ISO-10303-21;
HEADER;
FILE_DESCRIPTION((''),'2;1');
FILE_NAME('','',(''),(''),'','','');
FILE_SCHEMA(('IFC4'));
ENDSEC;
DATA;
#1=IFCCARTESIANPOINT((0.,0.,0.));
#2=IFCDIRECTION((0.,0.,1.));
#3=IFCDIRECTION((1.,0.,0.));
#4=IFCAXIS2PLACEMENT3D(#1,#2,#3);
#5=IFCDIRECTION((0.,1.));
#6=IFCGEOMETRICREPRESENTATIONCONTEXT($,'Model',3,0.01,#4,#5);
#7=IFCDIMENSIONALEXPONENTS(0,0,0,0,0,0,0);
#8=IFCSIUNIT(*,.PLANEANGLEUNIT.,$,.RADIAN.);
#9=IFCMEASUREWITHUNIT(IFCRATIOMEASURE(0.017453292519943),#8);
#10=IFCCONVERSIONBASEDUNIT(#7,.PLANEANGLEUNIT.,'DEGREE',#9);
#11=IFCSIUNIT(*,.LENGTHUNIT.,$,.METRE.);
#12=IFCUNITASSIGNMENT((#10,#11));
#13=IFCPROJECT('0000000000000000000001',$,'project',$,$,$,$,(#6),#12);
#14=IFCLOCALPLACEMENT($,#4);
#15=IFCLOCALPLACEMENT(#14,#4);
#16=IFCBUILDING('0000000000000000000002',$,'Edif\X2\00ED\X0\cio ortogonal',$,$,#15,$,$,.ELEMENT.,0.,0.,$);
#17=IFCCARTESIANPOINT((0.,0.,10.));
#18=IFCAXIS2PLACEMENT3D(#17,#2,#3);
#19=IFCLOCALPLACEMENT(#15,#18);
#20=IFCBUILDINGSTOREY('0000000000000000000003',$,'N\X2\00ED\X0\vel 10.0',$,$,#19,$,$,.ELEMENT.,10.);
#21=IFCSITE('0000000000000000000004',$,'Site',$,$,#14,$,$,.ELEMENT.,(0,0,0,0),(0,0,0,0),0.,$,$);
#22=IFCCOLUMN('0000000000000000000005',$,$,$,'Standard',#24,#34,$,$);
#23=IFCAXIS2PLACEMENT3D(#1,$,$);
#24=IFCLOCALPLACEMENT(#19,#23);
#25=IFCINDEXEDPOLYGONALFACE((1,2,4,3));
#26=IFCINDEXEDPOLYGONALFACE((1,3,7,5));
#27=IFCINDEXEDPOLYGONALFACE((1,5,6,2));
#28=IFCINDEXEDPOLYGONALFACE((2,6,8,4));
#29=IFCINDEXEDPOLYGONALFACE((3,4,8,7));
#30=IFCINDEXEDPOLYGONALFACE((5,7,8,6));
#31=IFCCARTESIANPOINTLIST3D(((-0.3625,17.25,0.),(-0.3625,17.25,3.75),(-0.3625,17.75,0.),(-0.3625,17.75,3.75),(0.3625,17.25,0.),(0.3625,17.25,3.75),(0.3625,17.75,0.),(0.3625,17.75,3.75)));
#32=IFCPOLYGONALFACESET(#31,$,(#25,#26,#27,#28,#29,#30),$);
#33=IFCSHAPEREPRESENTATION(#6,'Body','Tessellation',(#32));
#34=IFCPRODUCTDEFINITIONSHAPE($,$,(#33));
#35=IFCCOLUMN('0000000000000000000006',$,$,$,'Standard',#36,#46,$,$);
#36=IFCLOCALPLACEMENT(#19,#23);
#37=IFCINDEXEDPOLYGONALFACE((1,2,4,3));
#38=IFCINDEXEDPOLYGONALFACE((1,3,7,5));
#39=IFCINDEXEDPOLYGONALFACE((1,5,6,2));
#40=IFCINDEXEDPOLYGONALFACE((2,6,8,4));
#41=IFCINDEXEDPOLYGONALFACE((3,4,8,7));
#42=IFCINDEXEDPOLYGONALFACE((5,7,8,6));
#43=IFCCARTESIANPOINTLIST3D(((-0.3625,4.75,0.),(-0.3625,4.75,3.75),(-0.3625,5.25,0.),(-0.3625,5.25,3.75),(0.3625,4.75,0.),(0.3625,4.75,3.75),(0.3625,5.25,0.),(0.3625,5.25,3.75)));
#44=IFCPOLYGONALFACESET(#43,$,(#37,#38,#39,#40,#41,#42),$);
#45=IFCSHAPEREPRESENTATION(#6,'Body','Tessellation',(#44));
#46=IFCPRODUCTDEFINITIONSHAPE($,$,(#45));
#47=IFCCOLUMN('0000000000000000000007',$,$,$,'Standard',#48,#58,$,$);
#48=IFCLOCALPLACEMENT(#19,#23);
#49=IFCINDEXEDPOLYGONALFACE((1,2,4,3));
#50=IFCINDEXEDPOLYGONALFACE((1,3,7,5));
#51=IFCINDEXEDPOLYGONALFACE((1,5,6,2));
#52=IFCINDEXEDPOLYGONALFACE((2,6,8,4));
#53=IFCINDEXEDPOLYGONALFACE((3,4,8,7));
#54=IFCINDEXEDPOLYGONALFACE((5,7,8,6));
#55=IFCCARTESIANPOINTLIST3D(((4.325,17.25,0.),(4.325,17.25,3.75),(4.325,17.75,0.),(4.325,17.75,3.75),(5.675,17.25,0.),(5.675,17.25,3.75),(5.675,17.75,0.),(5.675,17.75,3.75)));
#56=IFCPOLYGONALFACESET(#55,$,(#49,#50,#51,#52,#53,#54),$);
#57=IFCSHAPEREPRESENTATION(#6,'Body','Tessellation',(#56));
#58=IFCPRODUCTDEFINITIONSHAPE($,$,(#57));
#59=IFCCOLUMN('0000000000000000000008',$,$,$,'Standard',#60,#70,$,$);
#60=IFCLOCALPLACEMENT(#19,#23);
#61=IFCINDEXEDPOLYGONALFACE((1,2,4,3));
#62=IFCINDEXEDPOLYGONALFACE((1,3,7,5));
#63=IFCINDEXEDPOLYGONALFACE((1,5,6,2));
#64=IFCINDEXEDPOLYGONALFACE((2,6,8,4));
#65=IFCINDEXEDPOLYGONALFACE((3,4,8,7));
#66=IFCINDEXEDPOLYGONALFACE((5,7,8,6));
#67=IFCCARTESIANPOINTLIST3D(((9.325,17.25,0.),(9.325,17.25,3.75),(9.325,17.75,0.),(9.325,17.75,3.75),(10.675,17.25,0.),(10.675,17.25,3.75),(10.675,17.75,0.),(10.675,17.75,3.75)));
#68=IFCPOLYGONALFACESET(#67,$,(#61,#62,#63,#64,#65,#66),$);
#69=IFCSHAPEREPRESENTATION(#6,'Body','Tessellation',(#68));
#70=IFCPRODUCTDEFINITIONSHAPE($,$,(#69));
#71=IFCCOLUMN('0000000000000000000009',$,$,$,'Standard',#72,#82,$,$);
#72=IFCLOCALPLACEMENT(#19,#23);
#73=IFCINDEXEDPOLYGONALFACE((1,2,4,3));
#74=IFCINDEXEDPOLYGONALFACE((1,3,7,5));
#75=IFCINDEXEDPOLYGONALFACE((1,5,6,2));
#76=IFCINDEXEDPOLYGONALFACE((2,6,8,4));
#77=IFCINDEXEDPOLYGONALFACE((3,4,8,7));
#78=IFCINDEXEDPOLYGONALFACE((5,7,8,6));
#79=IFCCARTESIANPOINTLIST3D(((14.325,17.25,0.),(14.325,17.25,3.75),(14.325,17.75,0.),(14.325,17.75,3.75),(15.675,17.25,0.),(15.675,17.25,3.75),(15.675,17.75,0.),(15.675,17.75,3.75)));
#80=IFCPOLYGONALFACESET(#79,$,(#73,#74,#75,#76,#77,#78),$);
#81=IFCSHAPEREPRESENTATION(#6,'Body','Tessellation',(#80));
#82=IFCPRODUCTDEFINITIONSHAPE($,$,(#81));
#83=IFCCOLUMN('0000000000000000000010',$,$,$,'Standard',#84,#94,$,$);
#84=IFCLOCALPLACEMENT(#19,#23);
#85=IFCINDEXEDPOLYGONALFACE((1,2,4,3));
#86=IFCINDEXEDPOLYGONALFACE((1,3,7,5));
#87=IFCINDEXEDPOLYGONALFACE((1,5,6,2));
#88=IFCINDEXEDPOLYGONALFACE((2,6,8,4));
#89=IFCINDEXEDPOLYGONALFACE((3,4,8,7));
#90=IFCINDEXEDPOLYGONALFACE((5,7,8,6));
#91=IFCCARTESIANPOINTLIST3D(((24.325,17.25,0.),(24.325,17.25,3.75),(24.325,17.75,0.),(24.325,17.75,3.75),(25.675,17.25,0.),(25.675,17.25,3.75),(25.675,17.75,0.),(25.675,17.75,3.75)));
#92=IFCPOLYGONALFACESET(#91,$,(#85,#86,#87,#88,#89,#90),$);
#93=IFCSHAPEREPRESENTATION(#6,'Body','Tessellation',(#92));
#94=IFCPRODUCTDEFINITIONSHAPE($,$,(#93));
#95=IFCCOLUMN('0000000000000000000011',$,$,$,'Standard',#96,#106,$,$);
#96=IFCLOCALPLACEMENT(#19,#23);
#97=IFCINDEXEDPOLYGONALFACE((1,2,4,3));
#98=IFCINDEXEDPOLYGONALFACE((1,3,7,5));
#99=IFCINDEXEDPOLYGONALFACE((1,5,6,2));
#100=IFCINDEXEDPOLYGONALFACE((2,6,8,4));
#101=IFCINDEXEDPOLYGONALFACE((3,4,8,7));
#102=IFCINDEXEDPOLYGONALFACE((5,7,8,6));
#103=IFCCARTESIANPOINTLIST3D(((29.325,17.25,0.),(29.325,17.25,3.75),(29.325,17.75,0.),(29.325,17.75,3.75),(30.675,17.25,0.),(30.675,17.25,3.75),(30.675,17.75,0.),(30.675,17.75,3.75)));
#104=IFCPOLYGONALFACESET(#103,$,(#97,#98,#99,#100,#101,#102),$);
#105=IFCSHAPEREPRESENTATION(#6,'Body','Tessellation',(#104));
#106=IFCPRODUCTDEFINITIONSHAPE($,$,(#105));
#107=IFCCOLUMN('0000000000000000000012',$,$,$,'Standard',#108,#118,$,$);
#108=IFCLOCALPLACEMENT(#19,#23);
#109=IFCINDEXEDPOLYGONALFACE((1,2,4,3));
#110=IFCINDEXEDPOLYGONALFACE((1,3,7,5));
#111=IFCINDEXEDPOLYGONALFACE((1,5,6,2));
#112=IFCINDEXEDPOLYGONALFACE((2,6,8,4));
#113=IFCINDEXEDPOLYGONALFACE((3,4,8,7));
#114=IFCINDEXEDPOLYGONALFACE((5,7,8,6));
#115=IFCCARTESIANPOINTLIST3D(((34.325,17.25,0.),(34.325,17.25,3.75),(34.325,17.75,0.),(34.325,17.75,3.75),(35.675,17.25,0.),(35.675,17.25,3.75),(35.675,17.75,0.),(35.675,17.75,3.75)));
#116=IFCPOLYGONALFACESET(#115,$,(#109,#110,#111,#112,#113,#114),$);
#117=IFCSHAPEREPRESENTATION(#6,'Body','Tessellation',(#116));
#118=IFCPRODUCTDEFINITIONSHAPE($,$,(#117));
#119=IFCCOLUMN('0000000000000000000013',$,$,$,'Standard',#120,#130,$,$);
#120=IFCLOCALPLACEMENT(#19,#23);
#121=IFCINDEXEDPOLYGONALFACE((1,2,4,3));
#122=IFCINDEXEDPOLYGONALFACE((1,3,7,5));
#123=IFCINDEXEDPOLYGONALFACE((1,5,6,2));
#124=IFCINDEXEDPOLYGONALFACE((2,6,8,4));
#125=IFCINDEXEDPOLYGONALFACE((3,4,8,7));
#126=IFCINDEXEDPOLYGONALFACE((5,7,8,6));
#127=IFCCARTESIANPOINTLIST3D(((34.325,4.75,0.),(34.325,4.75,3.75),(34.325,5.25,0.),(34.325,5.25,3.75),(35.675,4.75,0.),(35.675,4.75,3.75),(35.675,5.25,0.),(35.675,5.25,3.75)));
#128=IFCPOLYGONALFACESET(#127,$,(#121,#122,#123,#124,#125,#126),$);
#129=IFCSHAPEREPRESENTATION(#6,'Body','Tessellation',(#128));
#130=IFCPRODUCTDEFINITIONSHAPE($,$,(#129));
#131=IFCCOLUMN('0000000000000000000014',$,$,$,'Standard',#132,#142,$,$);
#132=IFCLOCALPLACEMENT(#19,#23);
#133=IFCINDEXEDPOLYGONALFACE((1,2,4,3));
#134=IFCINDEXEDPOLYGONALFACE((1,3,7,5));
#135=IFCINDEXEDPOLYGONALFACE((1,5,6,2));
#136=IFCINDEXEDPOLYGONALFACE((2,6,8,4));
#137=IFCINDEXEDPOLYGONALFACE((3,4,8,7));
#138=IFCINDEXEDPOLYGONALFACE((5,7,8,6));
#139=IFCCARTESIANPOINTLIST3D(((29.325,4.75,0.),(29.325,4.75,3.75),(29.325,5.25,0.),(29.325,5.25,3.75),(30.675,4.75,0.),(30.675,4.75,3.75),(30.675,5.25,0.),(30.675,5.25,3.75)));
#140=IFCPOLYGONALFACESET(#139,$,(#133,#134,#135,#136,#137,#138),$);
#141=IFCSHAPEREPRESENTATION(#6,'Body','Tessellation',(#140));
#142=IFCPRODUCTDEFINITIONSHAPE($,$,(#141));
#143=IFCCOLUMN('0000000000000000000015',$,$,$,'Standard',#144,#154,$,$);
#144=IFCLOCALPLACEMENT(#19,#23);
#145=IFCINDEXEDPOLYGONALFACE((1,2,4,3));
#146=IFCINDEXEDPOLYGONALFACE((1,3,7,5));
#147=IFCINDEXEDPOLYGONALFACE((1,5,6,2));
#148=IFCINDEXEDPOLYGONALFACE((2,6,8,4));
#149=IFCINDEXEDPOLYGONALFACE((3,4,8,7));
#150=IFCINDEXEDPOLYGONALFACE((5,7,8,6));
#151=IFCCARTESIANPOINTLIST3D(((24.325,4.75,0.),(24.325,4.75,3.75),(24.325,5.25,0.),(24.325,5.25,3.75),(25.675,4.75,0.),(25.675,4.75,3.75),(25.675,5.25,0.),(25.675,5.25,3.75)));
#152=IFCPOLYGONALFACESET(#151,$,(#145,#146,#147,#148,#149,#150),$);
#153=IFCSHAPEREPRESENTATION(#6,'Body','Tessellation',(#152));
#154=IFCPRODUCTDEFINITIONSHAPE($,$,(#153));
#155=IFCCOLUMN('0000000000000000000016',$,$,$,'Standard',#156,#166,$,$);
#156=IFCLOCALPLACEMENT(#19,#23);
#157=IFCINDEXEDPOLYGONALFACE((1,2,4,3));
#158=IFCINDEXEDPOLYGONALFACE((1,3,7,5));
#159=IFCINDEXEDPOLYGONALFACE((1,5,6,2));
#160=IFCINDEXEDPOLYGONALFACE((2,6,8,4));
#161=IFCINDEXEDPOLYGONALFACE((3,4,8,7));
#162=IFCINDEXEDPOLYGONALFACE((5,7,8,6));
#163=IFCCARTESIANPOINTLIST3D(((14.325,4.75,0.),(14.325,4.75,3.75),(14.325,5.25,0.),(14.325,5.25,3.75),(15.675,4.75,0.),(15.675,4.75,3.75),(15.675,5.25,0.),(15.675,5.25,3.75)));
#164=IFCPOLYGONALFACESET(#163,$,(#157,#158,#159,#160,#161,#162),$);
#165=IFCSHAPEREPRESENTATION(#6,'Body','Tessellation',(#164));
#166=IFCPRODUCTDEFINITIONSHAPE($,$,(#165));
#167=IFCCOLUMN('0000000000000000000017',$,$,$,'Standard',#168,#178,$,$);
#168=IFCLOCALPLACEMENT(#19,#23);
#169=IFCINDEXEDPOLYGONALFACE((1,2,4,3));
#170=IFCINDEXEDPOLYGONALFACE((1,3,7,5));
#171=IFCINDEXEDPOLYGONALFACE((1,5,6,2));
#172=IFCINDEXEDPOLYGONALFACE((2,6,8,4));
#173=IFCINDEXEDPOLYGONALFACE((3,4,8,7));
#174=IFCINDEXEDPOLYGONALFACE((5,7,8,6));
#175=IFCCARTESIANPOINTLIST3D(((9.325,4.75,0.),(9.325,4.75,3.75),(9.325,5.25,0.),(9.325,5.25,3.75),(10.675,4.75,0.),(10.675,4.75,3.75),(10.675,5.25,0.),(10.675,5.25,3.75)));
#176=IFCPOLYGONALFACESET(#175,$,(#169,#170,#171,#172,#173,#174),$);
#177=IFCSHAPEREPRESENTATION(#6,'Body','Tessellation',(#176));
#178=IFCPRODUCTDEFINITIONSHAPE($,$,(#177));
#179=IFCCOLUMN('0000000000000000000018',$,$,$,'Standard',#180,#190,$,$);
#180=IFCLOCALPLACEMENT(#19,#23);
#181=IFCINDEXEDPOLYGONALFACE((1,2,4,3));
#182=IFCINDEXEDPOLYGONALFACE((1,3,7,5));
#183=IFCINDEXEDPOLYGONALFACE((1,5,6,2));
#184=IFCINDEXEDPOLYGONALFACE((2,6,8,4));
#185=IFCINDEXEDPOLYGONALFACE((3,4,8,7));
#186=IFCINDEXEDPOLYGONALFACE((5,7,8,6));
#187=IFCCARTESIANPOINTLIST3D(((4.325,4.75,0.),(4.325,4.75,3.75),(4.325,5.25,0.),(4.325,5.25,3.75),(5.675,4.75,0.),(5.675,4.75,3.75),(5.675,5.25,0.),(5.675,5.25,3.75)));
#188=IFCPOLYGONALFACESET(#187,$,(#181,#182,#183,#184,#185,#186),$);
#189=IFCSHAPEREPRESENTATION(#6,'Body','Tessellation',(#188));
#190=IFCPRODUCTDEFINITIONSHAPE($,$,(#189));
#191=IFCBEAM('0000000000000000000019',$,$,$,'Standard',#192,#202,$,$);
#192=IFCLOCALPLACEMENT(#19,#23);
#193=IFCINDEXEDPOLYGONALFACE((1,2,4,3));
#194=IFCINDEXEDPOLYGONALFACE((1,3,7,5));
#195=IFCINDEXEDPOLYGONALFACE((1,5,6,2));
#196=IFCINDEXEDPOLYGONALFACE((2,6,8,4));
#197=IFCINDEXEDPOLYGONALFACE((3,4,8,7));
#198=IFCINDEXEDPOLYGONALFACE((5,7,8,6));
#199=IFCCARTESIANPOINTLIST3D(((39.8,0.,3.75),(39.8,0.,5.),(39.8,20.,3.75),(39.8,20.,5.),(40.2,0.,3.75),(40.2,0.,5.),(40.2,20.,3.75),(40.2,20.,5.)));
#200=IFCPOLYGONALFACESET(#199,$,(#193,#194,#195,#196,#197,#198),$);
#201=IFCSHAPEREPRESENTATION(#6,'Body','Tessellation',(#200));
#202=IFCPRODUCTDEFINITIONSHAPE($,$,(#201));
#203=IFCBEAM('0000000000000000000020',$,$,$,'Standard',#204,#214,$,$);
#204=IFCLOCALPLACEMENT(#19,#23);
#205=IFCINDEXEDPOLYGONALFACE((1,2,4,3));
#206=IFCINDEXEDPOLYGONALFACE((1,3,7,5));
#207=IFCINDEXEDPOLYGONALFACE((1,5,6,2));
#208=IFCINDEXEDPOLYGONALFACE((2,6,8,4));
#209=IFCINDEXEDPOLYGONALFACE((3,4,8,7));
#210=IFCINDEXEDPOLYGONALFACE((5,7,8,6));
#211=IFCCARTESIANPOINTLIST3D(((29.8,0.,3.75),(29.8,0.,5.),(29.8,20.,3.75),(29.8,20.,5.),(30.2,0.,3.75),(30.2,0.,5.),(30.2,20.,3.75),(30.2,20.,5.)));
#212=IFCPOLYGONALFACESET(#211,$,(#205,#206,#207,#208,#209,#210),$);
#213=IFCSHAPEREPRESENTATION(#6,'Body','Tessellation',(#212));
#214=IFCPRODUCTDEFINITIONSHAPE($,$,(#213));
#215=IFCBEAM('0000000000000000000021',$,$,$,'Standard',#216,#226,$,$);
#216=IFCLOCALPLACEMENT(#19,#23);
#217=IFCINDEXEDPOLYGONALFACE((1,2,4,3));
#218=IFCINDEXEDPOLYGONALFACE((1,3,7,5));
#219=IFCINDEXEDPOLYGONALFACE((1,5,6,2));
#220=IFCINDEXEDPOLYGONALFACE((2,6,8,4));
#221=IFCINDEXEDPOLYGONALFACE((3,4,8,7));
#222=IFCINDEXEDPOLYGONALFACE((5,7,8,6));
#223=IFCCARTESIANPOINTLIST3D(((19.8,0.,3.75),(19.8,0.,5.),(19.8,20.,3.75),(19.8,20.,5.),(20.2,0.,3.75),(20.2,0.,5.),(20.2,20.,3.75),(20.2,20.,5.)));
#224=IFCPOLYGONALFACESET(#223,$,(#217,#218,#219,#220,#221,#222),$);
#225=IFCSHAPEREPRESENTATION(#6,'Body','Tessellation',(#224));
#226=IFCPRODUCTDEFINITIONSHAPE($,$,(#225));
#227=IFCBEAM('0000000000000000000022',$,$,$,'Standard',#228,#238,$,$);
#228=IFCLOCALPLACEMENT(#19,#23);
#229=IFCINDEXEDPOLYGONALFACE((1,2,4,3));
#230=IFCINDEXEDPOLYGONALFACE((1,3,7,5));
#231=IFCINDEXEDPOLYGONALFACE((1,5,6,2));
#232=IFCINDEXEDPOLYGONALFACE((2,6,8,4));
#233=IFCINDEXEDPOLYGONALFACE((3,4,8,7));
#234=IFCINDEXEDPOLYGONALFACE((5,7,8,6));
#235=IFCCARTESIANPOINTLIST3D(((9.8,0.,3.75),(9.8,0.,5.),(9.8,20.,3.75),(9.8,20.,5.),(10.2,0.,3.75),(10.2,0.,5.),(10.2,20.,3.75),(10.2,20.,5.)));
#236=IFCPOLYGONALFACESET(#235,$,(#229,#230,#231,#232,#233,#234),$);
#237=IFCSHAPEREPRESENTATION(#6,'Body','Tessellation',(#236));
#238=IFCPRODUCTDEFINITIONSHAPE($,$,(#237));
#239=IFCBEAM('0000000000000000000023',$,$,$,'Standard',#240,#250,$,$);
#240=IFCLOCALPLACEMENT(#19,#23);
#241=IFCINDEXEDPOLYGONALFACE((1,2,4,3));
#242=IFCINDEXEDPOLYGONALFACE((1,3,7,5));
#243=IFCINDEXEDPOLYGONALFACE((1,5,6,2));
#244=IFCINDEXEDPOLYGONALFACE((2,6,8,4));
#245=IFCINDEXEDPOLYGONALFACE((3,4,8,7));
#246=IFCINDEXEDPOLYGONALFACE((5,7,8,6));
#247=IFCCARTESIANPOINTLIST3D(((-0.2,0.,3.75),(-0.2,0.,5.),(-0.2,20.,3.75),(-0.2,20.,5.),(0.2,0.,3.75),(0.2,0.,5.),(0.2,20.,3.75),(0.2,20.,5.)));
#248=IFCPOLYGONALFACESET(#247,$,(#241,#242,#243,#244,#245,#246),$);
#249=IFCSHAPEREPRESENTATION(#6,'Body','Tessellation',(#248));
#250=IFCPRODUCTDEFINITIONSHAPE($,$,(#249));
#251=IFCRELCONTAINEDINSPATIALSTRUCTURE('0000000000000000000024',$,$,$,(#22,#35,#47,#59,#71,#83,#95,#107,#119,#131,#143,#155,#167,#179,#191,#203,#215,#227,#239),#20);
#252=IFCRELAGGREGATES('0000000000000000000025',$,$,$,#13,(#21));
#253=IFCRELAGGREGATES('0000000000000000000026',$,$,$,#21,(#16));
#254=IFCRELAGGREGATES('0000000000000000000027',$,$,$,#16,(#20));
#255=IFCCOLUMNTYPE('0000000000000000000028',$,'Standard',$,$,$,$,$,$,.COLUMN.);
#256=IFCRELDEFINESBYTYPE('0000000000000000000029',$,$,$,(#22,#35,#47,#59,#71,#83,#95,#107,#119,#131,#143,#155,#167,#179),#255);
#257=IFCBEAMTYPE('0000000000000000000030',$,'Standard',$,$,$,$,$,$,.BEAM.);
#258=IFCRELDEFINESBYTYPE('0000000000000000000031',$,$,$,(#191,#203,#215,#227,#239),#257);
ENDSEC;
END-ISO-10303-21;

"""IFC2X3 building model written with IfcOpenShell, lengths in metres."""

from ifc_helpers import new_model, entity, si_unit, converted_unit, direction, frame, origin_with_axes, origin_2d, place, context, project, spatial, polyline, rectangle, outline, extrude, type_object, element, save


model = new_model("IFC2X3")

# Units and contexts
model_context = context("Model", 3, precision=0.01, world=origin_with_axes(), true_north=direction((0.0, 1.0)))
ifc_project = project(units=[converted_unit("PLANEANGLEUNIT", "DEGREE", entity("IfcRatioMeasure", 0.017453292519943), si_unit("PLANEANGLEUNIT", "RADIAN"), dimensions=[0, 0, 0, 0, 0, 0, 0]), si_unit("LENGTHUNIT", "METRE")], contexts=[model_context])

# Site, building, storey
site_placement = place(None, origin_with_axes())
site = spatial("IfcSite", under=ifc_project, at=site_placement, Name="Site", CompositionType="ELEMENT", RefLatitude=(0, 0, 0, 0), RefLongitude=(0, 0, 0, 0), RefElevation=0.0)
building_placement = place(site_placement, origin_with_axes())
building = spatial("IfcBuilding", under=site, at=building_placement, Name="Edifício ortogonal", CompositionType="ELEMENT", ElevationOfRefHeight=0.0, ElevationOfTerrain=0.0)
storey_placement = place(building_placement, frame((0.0, 0.0, 10.0), z_axis=(0.0, 0.0, 1.0), x_axis=(1.0, 0.0, 0.0)))
storey = spatial("IfcBuildingStorey", under=building, at=storey_placement, Name="Nível 10.0", CompositionType="ELEMENT", Elevation=10.0)

# Columns
column_type = type_object("IfcColumnType", Name="Standard", PredefinedType="COLUMN")
for number, where, z_axis, x_axis in (
    (1, (0.0, 17.5, 10.0), (0.0, 0.0, 1.0), (1.0, 0.0, 0.0)),
    (2, (0.0, 5.0, 10.0), (0.0, 0.0, 1.0), (1.0, 0.0, 0.0)),
):
    element("IfcColumn", number, at=place(site_placement, frame(where, z_axis=z_axis, x_axis=x_axis)), inside=storey, type_object=column_type, ObjectType="Standard", context=model_context, shape_type="SweptSolid", body=[
        extrude(outline(polyline([(0.3625, -0.25), (0.3625, 0.25), (-0.3625, 0.25), (-0.3625, -0.25), (0.3625, -0.25)])), origin_with_axes(), (0.0, 0.0, 1.0), 3.75),
    ])
for number, where, z_axis, x_axis in (
    (3, (5.0, 17.5, 10.0), (0.0, 0.0, 1.0), (1.0, 0.0, 0.0)),
    (4, (10.0, 17.5, 10.0), (0.0, 0.0, 1.0), (1.0, 0.0, 0.0)),
    (5, (15.0, 17.5, 10.0), (0.0, 0.0, 1.0), (1.0, 0.0, 0.0)),
    (6, (25.0, 17.5, 10.0), (0.0, 0.0, 1.0), (1.0, 0.0, 0.0)),
    (7, (30.0, 17.5, 10.0), (0.0, 0.0, 1.0), (1.0, 0.0, 0.0)),
    (8, (35.0, 17.5, 10.0), (0.0, 0.0, 1.0), (1.0, 0.0, 0.0)),
    (9, (35.0, 5.0, 10.0), (0.0, 0.0, 1.0), (1.0, 0.0, 0.0)),
    (10, (30.0, 5.0, 10.0), (0.0, 0.0, 1.0), (1.0, 0.0, 0.0)),
    (11, (25.0, 5.0, 10.0), (0.0, 0.0, 1.0), (1.0, 0.0, 0.0)),
    (12, (15.0, 5.0, 10.0), (0.0, 0.0, 1.0), (1.0, 0.0, 0.0)),
    (13, (10.0, 5.0, 10.0), (0.0, 0.0, 1.0), (1.0, 0.0, 0.0)),
    (14, (5.0, 5.0, 10.0), (0.0, 0.0, 1.0), (1.0, 0.0, 0.0)),
):
    element("IfcColumn", number, at=place(site_placement, frame(where, z_axis=z_axis, x_axis=x_axis)), inside=storey, type_object=column_type, ObjectType="Standard", context=model_context, shape_type="SweptSolid", body=[
        extrude(outline(polyline([(0.675, -0.25), (0.675, 0.25), (-0.675, 0.25), (-0.675, -0.25), (0.675, -0.25)])), origin_with_axes(), (0.0, 0.0, 1.0), 3.75),
    ])

# Beams
beam_type = type_object("IfcBeamType", Name="Standard", PredefinedType="BEAM")
for number, where, z_axis, x_axis in (
    (15, (40.0, 20.0, 15.0), (0.0, 0.0, 1.0), (0.0, -1.0, 0.0)),
    (16, (30.0, 20.0, 15.0), (0.0, 0.0, 1.0), (0.0, -1.0, 0.0)),
    (17, (20.0, 20.0, 15.0), (0.0, 0.0, 1.0), (0.0, -1.0, 0.0)),
    (18, (10.0, 20.0, 15.0), (0.0, 0.0, 1.0), (0.0, -1.0, 0.0)),
    (19, (0.0, 20.0, 15.0), (0.0, 0.0, 1.0), (0.0, -1.0, 0.0)),
):
    element("IfcBeam", number, at=place(site_placement, frame(where, z_axis=z_axis, x_axis=x_axis)), inside=storey, type_object=beam_type, ObjectType="Standard", context=model_context, shape_type="SweptSolid", body=[
        extrude(rectangle(XDim=0.4, YDim=1.25, at=origin_2d()), frame((0.0, 0.0, -0.625), z_axis=(1.0, 0.0, 0.0), x_axis=(0.0, 1.0, 0.0)), (0.0, 0.0, 1.0), 20.0),
    ])

save(model, "model.ifc")
